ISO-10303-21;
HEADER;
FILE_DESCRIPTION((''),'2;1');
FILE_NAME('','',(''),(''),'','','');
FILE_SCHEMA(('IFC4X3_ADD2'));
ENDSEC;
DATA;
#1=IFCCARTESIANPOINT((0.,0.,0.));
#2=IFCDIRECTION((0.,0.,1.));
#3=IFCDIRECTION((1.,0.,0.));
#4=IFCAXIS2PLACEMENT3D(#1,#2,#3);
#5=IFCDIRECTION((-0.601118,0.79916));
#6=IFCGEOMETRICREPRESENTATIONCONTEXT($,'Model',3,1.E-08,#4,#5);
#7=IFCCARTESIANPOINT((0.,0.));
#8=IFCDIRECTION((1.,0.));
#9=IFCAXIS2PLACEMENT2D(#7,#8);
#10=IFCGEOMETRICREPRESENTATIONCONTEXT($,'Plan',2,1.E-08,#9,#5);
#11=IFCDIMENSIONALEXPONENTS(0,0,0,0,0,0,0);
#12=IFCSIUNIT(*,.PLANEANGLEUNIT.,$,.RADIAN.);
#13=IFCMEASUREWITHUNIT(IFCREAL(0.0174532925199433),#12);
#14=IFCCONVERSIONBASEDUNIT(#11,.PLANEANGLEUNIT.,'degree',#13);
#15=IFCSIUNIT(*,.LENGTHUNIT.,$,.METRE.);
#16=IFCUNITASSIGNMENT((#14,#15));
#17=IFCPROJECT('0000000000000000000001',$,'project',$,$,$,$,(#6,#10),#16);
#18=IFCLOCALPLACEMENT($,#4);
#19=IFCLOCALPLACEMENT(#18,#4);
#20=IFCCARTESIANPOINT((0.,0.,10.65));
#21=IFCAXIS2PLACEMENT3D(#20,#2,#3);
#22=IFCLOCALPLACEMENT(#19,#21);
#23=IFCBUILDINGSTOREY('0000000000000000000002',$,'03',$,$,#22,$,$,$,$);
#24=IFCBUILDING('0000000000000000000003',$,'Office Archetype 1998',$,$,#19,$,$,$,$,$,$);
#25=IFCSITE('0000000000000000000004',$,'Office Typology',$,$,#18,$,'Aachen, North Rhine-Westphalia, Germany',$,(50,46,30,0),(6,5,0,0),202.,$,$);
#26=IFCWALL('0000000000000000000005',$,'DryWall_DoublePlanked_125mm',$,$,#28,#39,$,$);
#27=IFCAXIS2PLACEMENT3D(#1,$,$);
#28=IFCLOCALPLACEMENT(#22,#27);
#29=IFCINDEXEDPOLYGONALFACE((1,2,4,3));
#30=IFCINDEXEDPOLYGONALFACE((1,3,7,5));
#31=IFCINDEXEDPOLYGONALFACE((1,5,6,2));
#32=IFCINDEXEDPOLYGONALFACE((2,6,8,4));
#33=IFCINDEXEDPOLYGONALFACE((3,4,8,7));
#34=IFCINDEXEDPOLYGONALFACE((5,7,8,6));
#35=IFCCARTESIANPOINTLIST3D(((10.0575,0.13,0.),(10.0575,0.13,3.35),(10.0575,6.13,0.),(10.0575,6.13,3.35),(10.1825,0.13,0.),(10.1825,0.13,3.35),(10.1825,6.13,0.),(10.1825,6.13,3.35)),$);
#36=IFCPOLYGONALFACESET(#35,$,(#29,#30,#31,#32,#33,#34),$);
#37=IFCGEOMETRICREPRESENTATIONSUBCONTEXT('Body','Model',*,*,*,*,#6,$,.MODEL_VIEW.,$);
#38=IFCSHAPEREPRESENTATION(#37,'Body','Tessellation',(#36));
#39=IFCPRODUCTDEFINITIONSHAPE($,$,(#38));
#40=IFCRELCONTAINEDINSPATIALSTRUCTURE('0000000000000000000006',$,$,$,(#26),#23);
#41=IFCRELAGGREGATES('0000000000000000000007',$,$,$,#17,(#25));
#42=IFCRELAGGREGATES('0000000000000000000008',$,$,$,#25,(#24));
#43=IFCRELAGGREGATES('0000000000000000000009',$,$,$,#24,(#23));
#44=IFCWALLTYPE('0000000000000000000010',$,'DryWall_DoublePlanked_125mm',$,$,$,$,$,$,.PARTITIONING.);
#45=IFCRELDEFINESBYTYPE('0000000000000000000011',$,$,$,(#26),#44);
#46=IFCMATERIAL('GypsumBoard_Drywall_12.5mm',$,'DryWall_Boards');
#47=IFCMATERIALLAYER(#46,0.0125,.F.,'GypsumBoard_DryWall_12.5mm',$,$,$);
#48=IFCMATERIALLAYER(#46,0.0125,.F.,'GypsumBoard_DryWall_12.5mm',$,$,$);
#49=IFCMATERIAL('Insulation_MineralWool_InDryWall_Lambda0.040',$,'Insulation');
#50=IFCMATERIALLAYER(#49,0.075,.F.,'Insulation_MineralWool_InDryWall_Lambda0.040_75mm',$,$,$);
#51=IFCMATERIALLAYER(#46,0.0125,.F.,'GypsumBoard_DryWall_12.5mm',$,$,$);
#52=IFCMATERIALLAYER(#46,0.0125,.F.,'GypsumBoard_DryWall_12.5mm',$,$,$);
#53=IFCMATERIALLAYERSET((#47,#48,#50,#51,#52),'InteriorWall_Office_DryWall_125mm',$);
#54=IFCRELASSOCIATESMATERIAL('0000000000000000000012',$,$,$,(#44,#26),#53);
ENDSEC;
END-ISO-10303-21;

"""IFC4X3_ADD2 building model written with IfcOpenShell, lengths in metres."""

from ifc_helpers import new_model, entity, si_unit, converted_unit, direction, frame, origin_with_axes, origin_2d_with_axis, place, context, subcontext, project, spatial, line, indexed_curve, outline, extrude, material, layer, layer_set, layer_usage, type_object, element, save


model = new_model("IFC4X3_ADD2")

# Units and contexts
model_context = context("Model", 3, precision=1e-08, world=origin_with_axes(), true_north=direction((-0.601118, 0.79916)))
plan_context = context("Plan", 2, precision=1e-08, world=origin_2d_with_axis(), true_north=direction((-0.601118, 0.79916)))
body_context = subcontext(model_context, "Body", "Model", "MODEL_VIEW")
ifc_project = project(units=[converted_unit("PLANEANGLEUNIT", "degree", entity("IfcReal", 0.0174532925199433), si_unit("PLANEANGLEUNIT", "RADIAN"), dimensions=[0, 0, 0, 0, 0, 0, 0]), si_unit("LENGTHUNIT", "METRE")], contexts=[model_context, plan_context])

# Site, building, storey
site_placement = place(None, origin_with_axes())
site = spatial("IfcSite", under=ifc_project, at=site_placement, Name="Office Typology", LongName="Aachen, North Rhine-Westphalia, Germany", RefLatitude=(50, 46, 30, 0), RefLongitude=(6, 5, 0, 0), RefElevation=202.0)
building_placement = place(site_placement, origin_with_axes())
building = spatial("IfcBuilding", under=site, at=building_placement, Name="Office Archetype 1998")
storey_placement = place(building_placement, frame((0.0, 0.0, 10.65), z_axis=(0.0, 0.0, 1.0), x_axis=(1.0, 0.0, 0.0)))
storey = spatial("IfcBuildingStorey", under=building, at=storey_placement, Name="03")

# Wall
ifc_material_1 = material(Name="GypsumBoard_Drywall_12.5mm", Category="DryWall_Boards")
ifc_layer_1 = layer(ifc_material_1, 0.0125, ventilated=False, Name="GypsumBoard_DryWall_12.5mm")
ifc_layer_2 = layer(ifc_material_1, 0.0125, ventilated=False, Name="GypsumBoard_DryWall_12.5mm")
ifc_material_2 = material(Name="Insulation_MineralWool_InDryWall_Lambda0.040", Category="Insulation")
ifc_layer_3 = layer(ifc_material_2, 0.075, ventilated=False, Name="Insulation_MineralWool_InDryWall_Lambda0.040_75mm")
ifc_layer_4 = layer(ifc_material_1, 0.0125, ventilated=False, Name="GypsumBoard_DryWall_12.5mm")
ifc_layer_5 = layer(ifc_material_1, 0.0125, ventilated=False, Name="GypsumBoard_DryWall_12.5mm")
ifc_layer_set_1 = layer_set([ifc_layer_1, ifc_layer_2, ifc_layer_3, ifc_layer_4, ifc_layer_5], Name="InteriorWall_Office_DryWall_125mm")
wall_type_1 = type_object("IfcWallType", Name="DryWall_DoublePlanked_125mm", PredefinedType="PARTITIONING", material=ifc_layer_set_1)
ifc_layer_usage_1 = layer_usage(ifc_layer_set_1, "AXIS2", "POSITIVE", 0.0)
wall_1_placement = place(storey_placement, frame((10.0575, 6.13, 0.0), z_axis=(0.0, 0.0, 1.0), x_axis=(0.0, -1.0, 0.0)))
element("IfcWall", 1, at=wall_1_placement, inside=storey, type_object=wall_type_1, material=ifc_layer_usage_1, Name="DryWall_DoublePlanked_125mm", context=body_context, shape_type="SweptSolid", body=[
    extrude(outline(indexed_curve([(0.0, 0.0), (0.0, 0.125), (6.0, 0.125), (6.0, 0.0)], segments=[line(1, 2, 3, 4, 1)])), origin_with_axes(), (0.0, 0.0, 1.0), 3.35),
])

save(model, "model.ifc")
